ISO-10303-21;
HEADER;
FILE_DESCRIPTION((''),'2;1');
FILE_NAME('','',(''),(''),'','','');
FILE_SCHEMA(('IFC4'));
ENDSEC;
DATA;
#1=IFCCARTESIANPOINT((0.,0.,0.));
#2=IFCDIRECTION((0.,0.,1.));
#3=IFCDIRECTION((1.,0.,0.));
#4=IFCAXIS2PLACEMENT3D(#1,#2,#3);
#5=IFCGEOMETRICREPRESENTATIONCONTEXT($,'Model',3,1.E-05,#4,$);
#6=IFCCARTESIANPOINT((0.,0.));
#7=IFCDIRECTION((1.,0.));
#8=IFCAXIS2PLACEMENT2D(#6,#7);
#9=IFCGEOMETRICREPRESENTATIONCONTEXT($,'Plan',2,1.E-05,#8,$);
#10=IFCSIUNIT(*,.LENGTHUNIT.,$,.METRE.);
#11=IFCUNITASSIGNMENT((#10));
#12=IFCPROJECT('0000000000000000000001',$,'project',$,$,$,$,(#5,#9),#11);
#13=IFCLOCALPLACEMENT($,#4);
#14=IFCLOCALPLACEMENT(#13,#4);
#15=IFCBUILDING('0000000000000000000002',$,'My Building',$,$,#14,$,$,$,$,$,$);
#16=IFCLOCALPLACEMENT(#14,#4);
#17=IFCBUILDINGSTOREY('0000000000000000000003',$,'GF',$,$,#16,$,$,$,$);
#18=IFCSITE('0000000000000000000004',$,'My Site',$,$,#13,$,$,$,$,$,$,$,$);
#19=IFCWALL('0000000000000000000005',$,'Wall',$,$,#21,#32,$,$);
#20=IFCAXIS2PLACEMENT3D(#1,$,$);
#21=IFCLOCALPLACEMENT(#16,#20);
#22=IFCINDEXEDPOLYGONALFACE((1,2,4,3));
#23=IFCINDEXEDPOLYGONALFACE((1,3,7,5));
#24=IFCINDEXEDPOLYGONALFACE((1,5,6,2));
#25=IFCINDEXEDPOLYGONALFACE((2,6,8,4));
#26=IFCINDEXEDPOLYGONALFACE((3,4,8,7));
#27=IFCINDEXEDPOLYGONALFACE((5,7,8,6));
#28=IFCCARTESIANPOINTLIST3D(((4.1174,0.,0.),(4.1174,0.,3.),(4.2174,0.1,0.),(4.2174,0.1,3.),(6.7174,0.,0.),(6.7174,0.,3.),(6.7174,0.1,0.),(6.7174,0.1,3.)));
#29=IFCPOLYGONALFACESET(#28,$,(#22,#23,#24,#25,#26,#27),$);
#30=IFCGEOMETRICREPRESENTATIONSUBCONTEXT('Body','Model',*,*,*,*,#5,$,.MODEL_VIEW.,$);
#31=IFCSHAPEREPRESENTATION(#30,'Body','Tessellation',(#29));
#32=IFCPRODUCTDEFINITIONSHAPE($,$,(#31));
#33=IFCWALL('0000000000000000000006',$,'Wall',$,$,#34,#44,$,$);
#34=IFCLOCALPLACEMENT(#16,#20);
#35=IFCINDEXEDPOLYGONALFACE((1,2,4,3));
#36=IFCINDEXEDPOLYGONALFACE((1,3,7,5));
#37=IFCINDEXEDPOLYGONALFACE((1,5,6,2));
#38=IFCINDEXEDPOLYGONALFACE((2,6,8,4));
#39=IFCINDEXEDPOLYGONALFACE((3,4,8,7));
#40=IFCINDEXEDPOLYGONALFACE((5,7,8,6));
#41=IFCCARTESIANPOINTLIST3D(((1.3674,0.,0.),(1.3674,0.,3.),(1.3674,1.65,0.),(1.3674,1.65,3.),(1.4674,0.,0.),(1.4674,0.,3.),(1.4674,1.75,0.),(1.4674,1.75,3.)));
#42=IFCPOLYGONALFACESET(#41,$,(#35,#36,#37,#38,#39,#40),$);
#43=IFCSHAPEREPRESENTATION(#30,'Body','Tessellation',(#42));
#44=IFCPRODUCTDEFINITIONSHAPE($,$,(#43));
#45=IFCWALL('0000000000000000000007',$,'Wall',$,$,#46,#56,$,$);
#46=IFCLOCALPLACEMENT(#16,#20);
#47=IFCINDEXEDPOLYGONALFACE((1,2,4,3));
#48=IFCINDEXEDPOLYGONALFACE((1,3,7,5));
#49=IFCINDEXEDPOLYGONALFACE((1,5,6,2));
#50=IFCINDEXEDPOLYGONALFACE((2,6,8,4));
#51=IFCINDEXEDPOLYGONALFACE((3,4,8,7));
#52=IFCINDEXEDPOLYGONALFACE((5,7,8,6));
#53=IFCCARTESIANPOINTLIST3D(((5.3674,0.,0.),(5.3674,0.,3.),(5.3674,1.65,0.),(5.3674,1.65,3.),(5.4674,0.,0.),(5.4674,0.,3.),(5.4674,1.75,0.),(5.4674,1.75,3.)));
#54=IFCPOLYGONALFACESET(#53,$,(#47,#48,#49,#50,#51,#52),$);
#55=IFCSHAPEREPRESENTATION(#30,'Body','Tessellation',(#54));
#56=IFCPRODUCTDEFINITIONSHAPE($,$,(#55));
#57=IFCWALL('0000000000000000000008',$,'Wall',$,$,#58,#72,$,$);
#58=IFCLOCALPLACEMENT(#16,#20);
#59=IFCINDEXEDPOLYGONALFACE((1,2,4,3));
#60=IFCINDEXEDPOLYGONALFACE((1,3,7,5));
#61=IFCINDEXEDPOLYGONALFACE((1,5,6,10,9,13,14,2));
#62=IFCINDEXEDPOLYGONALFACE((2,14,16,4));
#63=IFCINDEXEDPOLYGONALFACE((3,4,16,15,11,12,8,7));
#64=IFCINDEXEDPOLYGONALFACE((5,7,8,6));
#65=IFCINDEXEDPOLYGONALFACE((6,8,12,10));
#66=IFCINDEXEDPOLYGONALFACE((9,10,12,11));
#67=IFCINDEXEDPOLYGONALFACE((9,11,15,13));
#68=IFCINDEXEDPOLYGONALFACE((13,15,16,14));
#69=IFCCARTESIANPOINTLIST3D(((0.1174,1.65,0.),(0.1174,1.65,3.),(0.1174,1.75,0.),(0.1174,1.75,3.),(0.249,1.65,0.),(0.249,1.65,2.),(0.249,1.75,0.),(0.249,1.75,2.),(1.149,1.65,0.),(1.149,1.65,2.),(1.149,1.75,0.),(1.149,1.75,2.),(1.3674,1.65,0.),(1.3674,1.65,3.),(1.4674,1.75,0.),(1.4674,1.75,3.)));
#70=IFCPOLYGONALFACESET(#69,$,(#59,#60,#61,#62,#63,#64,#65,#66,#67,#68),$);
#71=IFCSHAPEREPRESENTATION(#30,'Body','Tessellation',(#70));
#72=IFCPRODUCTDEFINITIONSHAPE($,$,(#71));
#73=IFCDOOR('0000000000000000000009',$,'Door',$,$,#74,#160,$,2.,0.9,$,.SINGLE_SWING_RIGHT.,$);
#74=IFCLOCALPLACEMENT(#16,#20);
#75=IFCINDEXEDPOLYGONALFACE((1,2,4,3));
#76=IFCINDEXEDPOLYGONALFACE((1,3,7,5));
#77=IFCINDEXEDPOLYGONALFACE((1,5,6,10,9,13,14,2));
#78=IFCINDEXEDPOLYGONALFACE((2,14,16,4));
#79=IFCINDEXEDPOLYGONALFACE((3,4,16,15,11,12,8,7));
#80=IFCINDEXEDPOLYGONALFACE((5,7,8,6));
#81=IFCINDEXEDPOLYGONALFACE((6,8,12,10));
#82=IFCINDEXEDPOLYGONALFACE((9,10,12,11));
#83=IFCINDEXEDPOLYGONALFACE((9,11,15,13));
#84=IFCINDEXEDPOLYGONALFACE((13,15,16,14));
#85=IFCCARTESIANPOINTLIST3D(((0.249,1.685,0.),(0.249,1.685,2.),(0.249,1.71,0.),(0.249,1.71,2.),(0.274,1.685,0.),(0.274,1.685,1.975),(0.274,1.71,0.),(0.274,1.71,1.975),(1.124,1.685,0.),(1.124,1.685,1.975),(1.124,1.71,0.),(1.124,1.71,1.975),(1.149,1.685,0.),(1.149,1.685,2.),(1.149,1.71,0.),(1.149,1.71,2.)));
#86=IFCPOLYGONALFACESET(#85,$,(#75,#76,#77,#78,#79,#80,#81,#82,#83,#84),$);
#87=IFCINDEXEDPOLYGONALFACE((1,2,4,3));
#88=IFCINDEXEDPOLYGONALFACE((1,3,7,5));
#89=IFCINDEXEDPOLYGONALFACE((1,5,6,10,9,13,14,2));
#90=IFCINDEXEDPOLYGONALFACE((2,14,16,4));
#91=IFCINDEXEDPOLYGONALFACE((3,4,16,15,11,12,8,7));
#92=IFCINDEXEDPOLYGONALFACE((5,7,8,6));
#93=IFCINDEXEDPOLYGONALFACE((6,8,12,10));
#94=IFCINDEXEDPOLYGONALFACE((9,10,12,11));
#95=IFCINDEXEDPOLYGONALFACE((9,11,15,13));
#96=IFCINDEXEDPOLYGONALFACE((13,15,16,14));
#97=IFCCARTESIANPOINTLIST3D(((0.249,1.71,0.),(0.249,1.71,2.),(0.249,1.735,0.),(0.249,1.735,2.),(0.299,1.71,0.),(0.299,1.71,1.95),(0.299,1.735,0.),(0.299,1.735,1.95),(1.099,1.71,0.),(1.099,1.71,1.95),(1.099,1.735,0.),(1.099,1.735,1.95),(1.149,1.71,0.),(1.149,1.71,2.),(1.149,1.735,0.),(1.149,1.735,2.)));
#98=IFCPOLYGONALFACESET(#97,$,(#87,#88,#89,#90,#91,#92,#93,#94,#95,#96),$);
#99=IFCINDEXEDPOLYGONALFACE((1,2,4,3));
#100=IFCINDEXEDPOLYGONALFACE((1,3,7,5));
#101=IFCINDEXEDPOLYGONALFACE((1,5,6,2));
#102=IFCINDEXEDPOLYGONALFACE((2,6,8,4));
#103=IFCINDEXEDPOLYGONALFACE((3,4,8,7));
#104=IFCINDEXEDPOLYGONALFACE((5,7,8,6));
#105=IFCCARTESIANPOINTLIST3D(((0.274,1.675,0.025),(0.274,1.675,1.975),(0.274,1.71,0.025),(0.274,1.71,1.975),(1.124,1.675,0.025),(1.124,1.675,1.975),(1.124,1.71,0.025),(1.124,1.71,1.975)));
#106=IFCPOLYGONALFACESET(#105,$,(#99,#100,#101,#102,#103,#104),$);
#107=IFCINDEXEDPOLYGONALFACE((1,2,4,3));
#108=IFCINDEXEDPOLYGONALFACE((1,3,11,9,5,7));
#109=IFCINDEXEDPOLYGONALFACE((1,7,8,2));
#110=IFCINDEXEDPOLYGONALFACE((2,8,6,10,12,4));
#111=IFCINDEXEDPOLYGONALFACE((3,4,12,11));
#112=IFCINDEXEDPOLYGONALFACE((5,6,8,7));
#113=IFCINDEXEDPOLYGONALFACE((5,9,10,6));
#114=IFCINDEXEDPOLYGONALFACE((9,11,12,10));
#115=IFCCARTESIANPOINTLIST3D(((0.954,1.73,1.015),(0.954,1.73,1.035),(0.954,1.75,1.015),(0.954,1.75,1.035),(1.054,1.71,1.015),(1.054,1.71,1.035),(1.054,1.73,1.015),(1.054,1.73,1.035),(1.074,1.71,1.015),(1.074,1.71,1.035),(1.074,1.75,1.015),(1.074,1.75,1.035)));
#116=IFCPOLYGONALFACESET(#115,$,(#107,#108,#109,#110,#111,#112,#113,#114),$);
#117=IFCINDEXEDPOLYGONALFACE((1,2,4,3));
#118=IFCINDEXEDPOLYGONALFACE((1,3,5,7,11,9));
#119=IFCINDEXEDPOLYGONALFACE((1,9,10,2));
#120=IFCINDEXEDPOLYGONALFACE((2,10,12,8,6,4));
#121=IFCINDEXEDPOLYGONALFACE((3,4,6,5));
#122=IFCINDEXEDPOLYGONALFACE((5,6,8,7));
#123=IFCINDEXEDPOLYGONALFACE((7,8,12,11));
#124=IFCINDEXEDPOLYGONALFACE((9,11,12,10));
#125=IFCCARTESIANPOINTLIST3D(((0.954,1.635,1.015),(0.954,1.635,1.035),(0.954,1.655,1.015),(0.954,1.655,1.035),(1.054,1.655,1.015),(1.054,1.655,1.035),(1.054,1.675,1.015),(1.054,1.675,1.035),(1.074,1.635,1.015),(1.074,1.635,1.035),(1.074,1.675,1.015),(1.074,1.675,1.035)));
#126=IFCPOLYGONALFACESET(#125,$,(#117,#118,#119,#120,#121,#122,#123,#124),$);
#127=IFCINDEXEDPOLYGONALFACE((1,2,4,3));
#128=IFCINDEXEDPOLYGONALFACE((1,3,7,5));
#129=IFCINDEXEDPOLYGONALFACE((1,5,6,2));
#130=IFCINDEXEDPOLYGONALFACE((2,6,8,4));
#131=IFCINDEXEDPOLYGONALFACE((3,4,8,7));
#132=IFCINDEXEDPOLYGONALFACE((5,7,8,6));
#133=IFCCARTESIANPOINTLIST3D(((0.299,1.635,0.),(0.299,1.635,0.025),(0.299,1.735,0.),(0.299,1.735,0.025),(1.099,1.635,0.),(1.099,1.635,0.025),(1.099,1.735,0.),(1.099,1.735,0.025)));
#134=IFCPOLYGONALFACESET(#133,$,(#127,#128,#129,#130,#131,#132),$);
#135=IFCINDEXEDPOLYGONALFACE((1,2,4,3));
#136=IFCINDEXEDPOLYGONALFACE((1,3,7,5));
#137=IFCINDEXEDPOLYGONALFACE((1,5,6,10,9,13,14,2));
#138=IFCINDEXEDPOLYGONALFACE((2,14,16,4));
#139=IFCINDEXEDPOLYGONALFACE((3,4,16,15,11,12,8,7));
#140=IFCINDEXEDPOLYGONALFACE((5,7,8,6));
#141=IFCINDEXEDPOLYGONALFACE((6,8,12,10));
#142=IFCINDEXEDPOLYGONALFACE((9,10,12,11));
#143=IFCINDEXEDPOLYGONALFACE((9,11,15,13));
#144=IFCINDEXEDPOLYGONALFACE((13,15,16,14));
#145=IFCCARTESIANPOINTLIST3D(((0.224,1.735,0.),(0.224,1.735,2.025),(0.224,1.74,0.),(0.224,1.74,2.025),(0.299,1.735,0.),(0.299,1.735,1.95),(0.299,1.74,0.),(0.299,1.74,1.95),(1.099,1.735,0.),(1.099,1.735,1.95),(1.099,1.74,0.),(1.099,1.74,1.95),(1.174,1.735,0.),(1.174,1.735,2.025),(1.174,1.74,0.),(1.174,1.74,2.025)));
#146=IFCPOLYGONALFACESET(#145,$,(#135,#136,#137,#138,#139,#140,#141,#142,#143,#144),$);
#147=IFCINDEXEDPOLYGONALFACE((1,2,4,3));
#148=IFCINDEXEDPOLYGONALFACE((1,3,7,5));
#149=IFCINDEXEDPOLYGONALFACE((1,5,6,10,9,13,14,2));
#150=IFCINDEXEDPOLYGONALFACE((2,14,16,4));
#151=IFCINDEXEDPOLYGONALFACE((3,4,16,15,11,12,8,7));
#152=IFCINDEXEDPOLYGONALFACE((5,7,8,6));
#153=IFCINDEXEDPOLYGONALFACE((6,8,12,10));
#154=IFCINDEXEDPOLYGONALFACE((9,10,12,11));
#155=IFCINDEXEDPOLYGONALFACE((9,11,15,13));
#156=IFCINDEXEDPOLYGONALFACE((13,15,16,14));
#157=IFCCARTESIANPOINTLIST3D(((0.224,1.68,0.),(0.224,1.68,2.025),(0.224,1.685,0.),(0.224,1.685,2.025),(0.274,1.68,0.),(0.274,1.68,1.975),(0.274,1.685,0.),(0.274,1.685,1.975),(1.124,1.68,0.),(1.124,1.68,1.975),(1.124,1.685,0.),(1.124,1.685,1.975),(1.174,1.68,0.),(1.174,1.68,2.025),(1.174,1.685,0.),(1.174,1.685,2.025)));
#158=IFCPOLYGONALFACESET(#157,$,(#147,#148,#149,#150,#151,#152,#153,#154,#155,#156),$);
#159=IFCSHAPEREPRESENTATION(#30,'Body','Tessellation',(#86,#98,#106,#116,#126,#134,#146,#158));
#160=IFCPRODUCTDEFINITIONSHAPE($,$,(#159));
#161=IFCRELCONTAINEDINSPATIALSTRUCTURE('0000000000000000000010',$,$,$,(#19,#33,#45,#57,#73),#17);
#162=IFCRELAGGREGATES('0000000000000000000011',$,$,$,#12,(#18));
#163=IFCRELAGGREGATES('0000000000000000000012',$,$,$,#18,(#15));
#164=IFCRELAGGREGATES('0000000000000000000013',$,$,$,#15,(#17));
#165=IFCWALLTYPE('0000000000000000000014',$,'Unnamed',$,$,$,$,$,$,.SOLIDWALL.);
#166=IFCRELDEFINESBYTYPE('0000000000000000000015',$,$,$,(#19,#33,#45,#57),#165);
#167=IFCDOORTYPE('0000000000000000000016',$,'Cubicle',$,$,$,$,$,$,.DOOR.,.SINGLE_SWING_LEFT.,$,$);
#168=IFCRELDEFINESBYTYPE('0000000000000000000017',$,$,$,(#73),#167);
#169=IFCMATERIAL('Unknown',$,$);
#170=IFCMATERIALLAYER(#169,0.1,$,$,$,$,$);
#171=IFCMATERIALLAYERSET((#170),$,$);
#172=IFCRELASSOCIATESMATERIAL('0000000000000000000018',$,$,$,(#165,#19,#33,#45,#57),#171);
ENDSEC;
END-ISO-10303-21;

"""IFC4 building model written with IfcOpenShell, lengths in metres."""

from ifc_helpers import new_model, entity, si_unit, frame, origin_with_axes, origin_2d_with_axis, place, context, subcontext, project, spatial, line, indexed_curve, outline, extrude, shape, source, transform, mapped, material, layer, layer_set, layer_usage, type_object, type_shapes, element, fill, save


model = new_model("IFC4")

# Units and contexts
model_context = context("Model", 3, precision=1e-05, world=origin_with_axes())
plan_context = context("Plan", 2, precision=1e-05, world=origin_2d_with_axis())
body_context_1 = subcontext(model_context, "Body", "Model", "MODEL_VIEW")
body_context_2 = subcontext(plan_context, "Body", "Plan", "PLAN_VIEW")
ifc_project = project(units=[si_unit("LENGTHUNIT", "METRE")], contexts=[model_context, plan_context])

# Site, building, storey
site_placement = place(None, origin_with_axes())
site = spatial("IfcSite", under=ifc_project, at=site_placement, Name="My Site")
building_placement = place(site_placement, origin_with_axes())
building = spatial("IfcBuilding", under=site, at=building_placement, Name="My Building")
storey_placement = place(building_placement, origin_with_axes())
storey = spatial("IfcBuildingStorey", under=building, at=storey_placement, Name="GF")

# Shared definitions
ifc_material = material(Name="Unknown")

# Walls
ifc_layer_1 = layer(ifc_material, 0.1)
ifc_layer_set_1 = layer_set([ifc_layer_1])
wall_type = type_object("IfcWallType", Name="Unnamed", PredefinedType="SOLIDWALL", material=ifc_layer_set_1)
ifc_layer_usage_1 = layer_usage(ifc_layer_set_1, "AXIS2", "POSITIVE", 0.0)
wall_1_placement = place(storey_placement, frame((4.1174, 0.0, 0.0), z_axis=(0.0, 0.0, 1.0), x_axis=(1.0, 0.0, 0.0)))
element("IfcWall", 1, at=wall_1_placement, inside=storey, type_object=wall_type, material=ifc_layer_usage_1, Name="Wall", context=body_context_1, shape_type="SweptSolid", body=[
    extrude(outline(indexed_curve([(0.0, 0.0), (0.1, 0.1), (2.6, 0.1), (2.6, 0.0)], segments=[line(1, 2, 3, 4, 1)])), origin_with_axes(), (0.0, 0.0, 1.0), 3.0),
])
ifc_layer_usage_2 = layer_usage(ifc_layer_set_1, "AXIS2", "POSITIVE", 0.0)
wall_2_placement = place(storey_placement, frame((1.4674, 0.0, 0.0), z_axis=(0.0, 0.0, 1.0), x_axis=(0.0, 1.0, 0.0)))
element("IfcWall", 2, at=wall_2_placement, inside=storey, type_object=wall_type, material=ifc_layer_usage_2, Name="Wall", context=body_context_1, shape_type="SweptSolid", body=[
    extrude(outline(indexed_curve([(0.0, 0.0), (0.0, 0.1), (1.65, 0.1), (1.75, 0.0)], segments=[line(1, 2, 3, 4, 1)])), origin_with_axes(), (0.0, 0.0, 1.0), 3.0),
])
ifc_layer_usage_3 = layer_usage(ifc_layer_set_1, "AXIS2", "POSITIVE", 0.0)
wall_3_placement = place(storey_placement, frame((5.4674, 0.0, 0.0), z_axis=(0.0, 0.0, 1.0), x_axis=(0.0, 1.0, 0.0)))
element("IfcWall", 3, at=wall_3_placement, inside=storey, type_object=wall_type, material=ifc_layer_usage_3, Name="Wall", context=body_context_1, shape_type="SweptSolid", body=[
    extrude(outline(indexed_curve([(0.0, 0.0), (0.0, 0.1), (1.65, 0.1), (1.75, 0.0)], segments=[line(1, 2, 3, 4, 1)])), origin_with_axes(), (0.0, 0.0, 1.0), 3.0),
])

# Wall, opening, door
ifc_layer_usage_4 = layer_usage(ifc_layer_set_1, "AXIS2", "POSITIVE", 0.0)
wall_4_placement = place(storey_placement, frame((1.4674, 1.75, 0.0), z_axis=(0.0, 0.0, 1.0), x_axis=(-1.0, 0.0, 0.0)))
wall_4 = element("IfcWall", 4, at=wall_4_placement, inside=storey, type_object=wall_type, material=ifc_layer_usage_4, Name="Wall", context=body_context_1, shape_type="SweptSolid", body=[
    extrude(outline(indexed_curve([(0.0, 0.0), (0.1, 0.1), (1.35, 0.1), (1.35, 0.0)], segments=[line(1, 2, 3, 4, 1)])), origin_with_axes(), (0.0, 0.0, 1.0), 3.0),
])
shared_shape_1 = source(origin_with_axes(), body_context_1, "Body", "SweptSolid", [
    extrude(outline(indexed_curve([(0.0, 0.0), (0.9, 0.0), (0.9, 2.0), (0.0, 2.0)], segments=[line(1, 2, 3, 4, 1)])), frame((0.0, -0.6, 0.0), z_axis=(0.0, -1.0, 0.0), x_axis=(1.0, 0.0, 0.0)), (0.0, 0.0, -1.0), 1.2),
])
opening_1_placement = place(wall_4_placement, frame((0.3184, 0.015, 0.0), z_axis=(0.0, 0.0, 1.0), x_axis=(1.0, 0.0, 0.0)))
opening_1 = element("IfcOpeningElement", 5, at=opening_1_placement, cuts=wall_4, PredefinedType="OPENING", context=body_context_1, shape_type="MappedRepresentation", body=[
    mapped(shared_shape_1, transform((0.0, 0.0, 0.0), x_axis=(1.0, 0.0, 0.0), y_axis=(0.0, 1.0, 0.0), z_axis=(0.0, 0.0, 1.0), scale=1.0)),
])
door_type = type_object("IfcDoorType", Name="Cubicle", OperationType="SINGLE_SWING_LEFT", PredefinedType="DOOR")
shared_shape_2 = source(origin_with_axes(), body_context_1, "Body", "SweptSolid", [
    extrude(outline(indexed_curve([(0.0, 0.0), (0.0, 2.0), (0.9, 2.0), (0.9, 0.0), (0.875, 0.0), (0.875, 1.975), (0.025, 1.975), (0.025, 0.0)], segments=[line(1, 2, 3, 4, 5, 6, 7, 8, 1)])), frame((0.0, 0.025, 0.0), z_axis=(0.0, -1.0, 0.0), x_axis=(1.0, 0.0, 0.0)), (0.0, 0.0, -1.0), 0.025),
    extrude(outline(indexed_curve([(0.0, 0.0), (0.0, 2.0), (0.9, 2.0), (0.9, 0.0), (0.85, 0.0), (0.85, 1.95), (0.05, 1.95), (0.05, 0.0)], segments=[line(1, 2, 3, 4, 5, 6, 7, 8, 1)])), frame((0.0, 0.0, 0.0), z_axis=(0.0, -1.0, 0.0), x_axis=(1.0, 0.0, 0.0)), (0.0, 0.0, -1.0), 0.025),
    extrude(outline(indexed_curve([(0.0, 0.0), (0.85, 0.0), (0.85, 0.035), (0.0, 0.035)], segments=[line(1, 2, 3, 4, 1)])), frame((0.025, 0.025, 0.025), z_axis=(0.0, 0.0, 1.0), x_axis=(1.0, 0.0, 0.0)), (0.0, 0.0, 1.0), 1.95),
    extrude(outline(indexed_curve([(0.0, 0.0), (0.0, -0.04), (0.12, -0.04), (0.12, -0.02), (0.02, -0.02), (0.02, 0.0)], segments=[line(1, 2, 3, 4, 5, 6, 1)])), frame((0.075, 0.025, 1.015), z_axis=(0.0, 0.0, 1.0), x_axis=(1.0, 0.0, 0.0)), (0.0, 0.0, 1.0), 0.02),
    extrude(outline(indexed_curve([(0.0, 0.0), (0.0, 0.04), (0.12, 0.04), (0.12, 0.02), (0.02, 0.02), (0.02, 0.0)], segments=[line(1, 2, 3, 4, 5, 6, 1)])), frame((0.075, 0.06, 1.015), z_axis=(0.0, 0.0, 1.0), x_axis=(1.0, 0.0, 0.0)), (0.0, 0.0, 1.0), 0.02),
    extrude(outline(indexed_curve([(0.0, 0.0), (0.8, 0.0), (0.8, 0.1), (0.0, 0.1)], segments=[line(1, 2, 3, 4, 1)])), frame((0.05, 0.0, 0.0), z_axis=(0.0, 0.0, 1.0), x_axis=(1.0, 0.0, 0.0)), (0.0, 0.0, 1.0), 0.025),
    extrude(outline(indexed_curve([(0.0, 0.0), (0.0, 2.025), (0.95, 2.025), (0.95, 0.0), (0.875, 0.0), (0.875, 1.95), (0.075, 1.95), (0.075, 0.0)], segments=[line(1, 2, 3, 4, 5, 6, 7, 8, 1)])), frame((-0.025, -0.005, 0.0), z_axis=(0.0, -1.0, 0.0), x_axis=(1.0, 0.0, 0.0)), (0.0, 0.0, -1.0), 0.005),
    extrude(outline(indexed_curve([(0.0, 0.0), (0.0, 2.025), (0.95, 2.025), (0.95, 0.0), (0.9, 0.0), (0.9, 1.975), (0.05, 1.975), (0.05, 0.0)], segments=[line(1, 2, 3, 4, 5, 6, 7, 8, 1)])), frame((-0.025, 0.05, 0.0), z_axis=(0.0, -1.0, 0.0), x_axis=(1.0, 0.0, 0.0)), (0.0, 0.0, -1.0), 0.005),
])
shared_shape_3 = source(origin_with_axes(), body_context_2, "Body", "Curve2D", [
    entity("IfcIndexedPolyCurve", entity("IfcCartesianPointList2D", [[0.0, 0.0], [0.0, 0.05], [0.025, 0.05], [0.025, 0.025], [0.05, 0.025], [0.05, 0.0]]), [entity("IfcLineIndex", [1, 2, 3, 4, 5, 6, 1])]),
    entity("IfcIndexedPolyCurve", entity("IfcCartesianPointList2D", [[0.9, 0.0], [0.9, 0.05], [0.875, 0.05], [0.875, 0.025], [0.85, 0.025], [0.85, 0.0]]), [entity("IfcLineIndex", [1, 2, 3, 4, 5, 6, 1])]),
    entity("IfcTrimmedCurve", entity("IfcEllipse", entity("IfcAxis2Placement2D", entity("IfcCartesianPoint", [0.84, 0.05]), entity("IfcDirection", [1.0, 0.0])), 0.815, 0.85), [entity("IfcCartesianPoint", [0.84, 0.9])], [entity("IfcCartesianPoint", [0.025, 0.05])], True, "CARTESIAN"),
    entity("IfcIndexedPolyCurve", entity("IfcCartesianPointList2D", [[0.875, 0.05], [0.84, 0.05], [0.84, 0.9], [0.875, 0.9]]), [entity("IfcLineIndex", [1, 2, 3, 4, 1])]),
])
type_shapes(door_type, [shared_shape_2, shared_shape_3])
door_1_placement = place(opening_1_placement, frame((0.0, 0.0, 0.0), z_axis=(0.0, 0.0, 1.0), x_axis=(1.0, 0.0, 0.0)))
door_1 = element("IfcDoor", 6, at=door_1_placement, inside=storey, type_object=door_type, Name="Door", OperationType="SINGLE_SWING_RIGHT", OverallHeight=2.0, OverallWidth=0.9, shapes=[
    shape(body_context_1, "Body", "MappedRepresentation", [mapped(shared_shape_2, transform((0.0, 0.0, 0.0), x_axis=(1.0, 0.0, 0.0), y_axis=(0.0, 1.0, 0.0), z_axis=(0.0, 0.0, 1.0), scale=1.0))]),
    shape(body_context_2, "Body", "MappedRepresentation", [mapped(shared_shape_3, transform((0.0, 0.0, 0.0), x_axis=(1.0, 0.0, 0.0), y_axis=(0.0, 1.0, 0.0), z_axis=(0.0, 0.0, 1.0), scale=1.0))]),
])
fill(opening_1, door_1)

save(model, "model.ifc")
